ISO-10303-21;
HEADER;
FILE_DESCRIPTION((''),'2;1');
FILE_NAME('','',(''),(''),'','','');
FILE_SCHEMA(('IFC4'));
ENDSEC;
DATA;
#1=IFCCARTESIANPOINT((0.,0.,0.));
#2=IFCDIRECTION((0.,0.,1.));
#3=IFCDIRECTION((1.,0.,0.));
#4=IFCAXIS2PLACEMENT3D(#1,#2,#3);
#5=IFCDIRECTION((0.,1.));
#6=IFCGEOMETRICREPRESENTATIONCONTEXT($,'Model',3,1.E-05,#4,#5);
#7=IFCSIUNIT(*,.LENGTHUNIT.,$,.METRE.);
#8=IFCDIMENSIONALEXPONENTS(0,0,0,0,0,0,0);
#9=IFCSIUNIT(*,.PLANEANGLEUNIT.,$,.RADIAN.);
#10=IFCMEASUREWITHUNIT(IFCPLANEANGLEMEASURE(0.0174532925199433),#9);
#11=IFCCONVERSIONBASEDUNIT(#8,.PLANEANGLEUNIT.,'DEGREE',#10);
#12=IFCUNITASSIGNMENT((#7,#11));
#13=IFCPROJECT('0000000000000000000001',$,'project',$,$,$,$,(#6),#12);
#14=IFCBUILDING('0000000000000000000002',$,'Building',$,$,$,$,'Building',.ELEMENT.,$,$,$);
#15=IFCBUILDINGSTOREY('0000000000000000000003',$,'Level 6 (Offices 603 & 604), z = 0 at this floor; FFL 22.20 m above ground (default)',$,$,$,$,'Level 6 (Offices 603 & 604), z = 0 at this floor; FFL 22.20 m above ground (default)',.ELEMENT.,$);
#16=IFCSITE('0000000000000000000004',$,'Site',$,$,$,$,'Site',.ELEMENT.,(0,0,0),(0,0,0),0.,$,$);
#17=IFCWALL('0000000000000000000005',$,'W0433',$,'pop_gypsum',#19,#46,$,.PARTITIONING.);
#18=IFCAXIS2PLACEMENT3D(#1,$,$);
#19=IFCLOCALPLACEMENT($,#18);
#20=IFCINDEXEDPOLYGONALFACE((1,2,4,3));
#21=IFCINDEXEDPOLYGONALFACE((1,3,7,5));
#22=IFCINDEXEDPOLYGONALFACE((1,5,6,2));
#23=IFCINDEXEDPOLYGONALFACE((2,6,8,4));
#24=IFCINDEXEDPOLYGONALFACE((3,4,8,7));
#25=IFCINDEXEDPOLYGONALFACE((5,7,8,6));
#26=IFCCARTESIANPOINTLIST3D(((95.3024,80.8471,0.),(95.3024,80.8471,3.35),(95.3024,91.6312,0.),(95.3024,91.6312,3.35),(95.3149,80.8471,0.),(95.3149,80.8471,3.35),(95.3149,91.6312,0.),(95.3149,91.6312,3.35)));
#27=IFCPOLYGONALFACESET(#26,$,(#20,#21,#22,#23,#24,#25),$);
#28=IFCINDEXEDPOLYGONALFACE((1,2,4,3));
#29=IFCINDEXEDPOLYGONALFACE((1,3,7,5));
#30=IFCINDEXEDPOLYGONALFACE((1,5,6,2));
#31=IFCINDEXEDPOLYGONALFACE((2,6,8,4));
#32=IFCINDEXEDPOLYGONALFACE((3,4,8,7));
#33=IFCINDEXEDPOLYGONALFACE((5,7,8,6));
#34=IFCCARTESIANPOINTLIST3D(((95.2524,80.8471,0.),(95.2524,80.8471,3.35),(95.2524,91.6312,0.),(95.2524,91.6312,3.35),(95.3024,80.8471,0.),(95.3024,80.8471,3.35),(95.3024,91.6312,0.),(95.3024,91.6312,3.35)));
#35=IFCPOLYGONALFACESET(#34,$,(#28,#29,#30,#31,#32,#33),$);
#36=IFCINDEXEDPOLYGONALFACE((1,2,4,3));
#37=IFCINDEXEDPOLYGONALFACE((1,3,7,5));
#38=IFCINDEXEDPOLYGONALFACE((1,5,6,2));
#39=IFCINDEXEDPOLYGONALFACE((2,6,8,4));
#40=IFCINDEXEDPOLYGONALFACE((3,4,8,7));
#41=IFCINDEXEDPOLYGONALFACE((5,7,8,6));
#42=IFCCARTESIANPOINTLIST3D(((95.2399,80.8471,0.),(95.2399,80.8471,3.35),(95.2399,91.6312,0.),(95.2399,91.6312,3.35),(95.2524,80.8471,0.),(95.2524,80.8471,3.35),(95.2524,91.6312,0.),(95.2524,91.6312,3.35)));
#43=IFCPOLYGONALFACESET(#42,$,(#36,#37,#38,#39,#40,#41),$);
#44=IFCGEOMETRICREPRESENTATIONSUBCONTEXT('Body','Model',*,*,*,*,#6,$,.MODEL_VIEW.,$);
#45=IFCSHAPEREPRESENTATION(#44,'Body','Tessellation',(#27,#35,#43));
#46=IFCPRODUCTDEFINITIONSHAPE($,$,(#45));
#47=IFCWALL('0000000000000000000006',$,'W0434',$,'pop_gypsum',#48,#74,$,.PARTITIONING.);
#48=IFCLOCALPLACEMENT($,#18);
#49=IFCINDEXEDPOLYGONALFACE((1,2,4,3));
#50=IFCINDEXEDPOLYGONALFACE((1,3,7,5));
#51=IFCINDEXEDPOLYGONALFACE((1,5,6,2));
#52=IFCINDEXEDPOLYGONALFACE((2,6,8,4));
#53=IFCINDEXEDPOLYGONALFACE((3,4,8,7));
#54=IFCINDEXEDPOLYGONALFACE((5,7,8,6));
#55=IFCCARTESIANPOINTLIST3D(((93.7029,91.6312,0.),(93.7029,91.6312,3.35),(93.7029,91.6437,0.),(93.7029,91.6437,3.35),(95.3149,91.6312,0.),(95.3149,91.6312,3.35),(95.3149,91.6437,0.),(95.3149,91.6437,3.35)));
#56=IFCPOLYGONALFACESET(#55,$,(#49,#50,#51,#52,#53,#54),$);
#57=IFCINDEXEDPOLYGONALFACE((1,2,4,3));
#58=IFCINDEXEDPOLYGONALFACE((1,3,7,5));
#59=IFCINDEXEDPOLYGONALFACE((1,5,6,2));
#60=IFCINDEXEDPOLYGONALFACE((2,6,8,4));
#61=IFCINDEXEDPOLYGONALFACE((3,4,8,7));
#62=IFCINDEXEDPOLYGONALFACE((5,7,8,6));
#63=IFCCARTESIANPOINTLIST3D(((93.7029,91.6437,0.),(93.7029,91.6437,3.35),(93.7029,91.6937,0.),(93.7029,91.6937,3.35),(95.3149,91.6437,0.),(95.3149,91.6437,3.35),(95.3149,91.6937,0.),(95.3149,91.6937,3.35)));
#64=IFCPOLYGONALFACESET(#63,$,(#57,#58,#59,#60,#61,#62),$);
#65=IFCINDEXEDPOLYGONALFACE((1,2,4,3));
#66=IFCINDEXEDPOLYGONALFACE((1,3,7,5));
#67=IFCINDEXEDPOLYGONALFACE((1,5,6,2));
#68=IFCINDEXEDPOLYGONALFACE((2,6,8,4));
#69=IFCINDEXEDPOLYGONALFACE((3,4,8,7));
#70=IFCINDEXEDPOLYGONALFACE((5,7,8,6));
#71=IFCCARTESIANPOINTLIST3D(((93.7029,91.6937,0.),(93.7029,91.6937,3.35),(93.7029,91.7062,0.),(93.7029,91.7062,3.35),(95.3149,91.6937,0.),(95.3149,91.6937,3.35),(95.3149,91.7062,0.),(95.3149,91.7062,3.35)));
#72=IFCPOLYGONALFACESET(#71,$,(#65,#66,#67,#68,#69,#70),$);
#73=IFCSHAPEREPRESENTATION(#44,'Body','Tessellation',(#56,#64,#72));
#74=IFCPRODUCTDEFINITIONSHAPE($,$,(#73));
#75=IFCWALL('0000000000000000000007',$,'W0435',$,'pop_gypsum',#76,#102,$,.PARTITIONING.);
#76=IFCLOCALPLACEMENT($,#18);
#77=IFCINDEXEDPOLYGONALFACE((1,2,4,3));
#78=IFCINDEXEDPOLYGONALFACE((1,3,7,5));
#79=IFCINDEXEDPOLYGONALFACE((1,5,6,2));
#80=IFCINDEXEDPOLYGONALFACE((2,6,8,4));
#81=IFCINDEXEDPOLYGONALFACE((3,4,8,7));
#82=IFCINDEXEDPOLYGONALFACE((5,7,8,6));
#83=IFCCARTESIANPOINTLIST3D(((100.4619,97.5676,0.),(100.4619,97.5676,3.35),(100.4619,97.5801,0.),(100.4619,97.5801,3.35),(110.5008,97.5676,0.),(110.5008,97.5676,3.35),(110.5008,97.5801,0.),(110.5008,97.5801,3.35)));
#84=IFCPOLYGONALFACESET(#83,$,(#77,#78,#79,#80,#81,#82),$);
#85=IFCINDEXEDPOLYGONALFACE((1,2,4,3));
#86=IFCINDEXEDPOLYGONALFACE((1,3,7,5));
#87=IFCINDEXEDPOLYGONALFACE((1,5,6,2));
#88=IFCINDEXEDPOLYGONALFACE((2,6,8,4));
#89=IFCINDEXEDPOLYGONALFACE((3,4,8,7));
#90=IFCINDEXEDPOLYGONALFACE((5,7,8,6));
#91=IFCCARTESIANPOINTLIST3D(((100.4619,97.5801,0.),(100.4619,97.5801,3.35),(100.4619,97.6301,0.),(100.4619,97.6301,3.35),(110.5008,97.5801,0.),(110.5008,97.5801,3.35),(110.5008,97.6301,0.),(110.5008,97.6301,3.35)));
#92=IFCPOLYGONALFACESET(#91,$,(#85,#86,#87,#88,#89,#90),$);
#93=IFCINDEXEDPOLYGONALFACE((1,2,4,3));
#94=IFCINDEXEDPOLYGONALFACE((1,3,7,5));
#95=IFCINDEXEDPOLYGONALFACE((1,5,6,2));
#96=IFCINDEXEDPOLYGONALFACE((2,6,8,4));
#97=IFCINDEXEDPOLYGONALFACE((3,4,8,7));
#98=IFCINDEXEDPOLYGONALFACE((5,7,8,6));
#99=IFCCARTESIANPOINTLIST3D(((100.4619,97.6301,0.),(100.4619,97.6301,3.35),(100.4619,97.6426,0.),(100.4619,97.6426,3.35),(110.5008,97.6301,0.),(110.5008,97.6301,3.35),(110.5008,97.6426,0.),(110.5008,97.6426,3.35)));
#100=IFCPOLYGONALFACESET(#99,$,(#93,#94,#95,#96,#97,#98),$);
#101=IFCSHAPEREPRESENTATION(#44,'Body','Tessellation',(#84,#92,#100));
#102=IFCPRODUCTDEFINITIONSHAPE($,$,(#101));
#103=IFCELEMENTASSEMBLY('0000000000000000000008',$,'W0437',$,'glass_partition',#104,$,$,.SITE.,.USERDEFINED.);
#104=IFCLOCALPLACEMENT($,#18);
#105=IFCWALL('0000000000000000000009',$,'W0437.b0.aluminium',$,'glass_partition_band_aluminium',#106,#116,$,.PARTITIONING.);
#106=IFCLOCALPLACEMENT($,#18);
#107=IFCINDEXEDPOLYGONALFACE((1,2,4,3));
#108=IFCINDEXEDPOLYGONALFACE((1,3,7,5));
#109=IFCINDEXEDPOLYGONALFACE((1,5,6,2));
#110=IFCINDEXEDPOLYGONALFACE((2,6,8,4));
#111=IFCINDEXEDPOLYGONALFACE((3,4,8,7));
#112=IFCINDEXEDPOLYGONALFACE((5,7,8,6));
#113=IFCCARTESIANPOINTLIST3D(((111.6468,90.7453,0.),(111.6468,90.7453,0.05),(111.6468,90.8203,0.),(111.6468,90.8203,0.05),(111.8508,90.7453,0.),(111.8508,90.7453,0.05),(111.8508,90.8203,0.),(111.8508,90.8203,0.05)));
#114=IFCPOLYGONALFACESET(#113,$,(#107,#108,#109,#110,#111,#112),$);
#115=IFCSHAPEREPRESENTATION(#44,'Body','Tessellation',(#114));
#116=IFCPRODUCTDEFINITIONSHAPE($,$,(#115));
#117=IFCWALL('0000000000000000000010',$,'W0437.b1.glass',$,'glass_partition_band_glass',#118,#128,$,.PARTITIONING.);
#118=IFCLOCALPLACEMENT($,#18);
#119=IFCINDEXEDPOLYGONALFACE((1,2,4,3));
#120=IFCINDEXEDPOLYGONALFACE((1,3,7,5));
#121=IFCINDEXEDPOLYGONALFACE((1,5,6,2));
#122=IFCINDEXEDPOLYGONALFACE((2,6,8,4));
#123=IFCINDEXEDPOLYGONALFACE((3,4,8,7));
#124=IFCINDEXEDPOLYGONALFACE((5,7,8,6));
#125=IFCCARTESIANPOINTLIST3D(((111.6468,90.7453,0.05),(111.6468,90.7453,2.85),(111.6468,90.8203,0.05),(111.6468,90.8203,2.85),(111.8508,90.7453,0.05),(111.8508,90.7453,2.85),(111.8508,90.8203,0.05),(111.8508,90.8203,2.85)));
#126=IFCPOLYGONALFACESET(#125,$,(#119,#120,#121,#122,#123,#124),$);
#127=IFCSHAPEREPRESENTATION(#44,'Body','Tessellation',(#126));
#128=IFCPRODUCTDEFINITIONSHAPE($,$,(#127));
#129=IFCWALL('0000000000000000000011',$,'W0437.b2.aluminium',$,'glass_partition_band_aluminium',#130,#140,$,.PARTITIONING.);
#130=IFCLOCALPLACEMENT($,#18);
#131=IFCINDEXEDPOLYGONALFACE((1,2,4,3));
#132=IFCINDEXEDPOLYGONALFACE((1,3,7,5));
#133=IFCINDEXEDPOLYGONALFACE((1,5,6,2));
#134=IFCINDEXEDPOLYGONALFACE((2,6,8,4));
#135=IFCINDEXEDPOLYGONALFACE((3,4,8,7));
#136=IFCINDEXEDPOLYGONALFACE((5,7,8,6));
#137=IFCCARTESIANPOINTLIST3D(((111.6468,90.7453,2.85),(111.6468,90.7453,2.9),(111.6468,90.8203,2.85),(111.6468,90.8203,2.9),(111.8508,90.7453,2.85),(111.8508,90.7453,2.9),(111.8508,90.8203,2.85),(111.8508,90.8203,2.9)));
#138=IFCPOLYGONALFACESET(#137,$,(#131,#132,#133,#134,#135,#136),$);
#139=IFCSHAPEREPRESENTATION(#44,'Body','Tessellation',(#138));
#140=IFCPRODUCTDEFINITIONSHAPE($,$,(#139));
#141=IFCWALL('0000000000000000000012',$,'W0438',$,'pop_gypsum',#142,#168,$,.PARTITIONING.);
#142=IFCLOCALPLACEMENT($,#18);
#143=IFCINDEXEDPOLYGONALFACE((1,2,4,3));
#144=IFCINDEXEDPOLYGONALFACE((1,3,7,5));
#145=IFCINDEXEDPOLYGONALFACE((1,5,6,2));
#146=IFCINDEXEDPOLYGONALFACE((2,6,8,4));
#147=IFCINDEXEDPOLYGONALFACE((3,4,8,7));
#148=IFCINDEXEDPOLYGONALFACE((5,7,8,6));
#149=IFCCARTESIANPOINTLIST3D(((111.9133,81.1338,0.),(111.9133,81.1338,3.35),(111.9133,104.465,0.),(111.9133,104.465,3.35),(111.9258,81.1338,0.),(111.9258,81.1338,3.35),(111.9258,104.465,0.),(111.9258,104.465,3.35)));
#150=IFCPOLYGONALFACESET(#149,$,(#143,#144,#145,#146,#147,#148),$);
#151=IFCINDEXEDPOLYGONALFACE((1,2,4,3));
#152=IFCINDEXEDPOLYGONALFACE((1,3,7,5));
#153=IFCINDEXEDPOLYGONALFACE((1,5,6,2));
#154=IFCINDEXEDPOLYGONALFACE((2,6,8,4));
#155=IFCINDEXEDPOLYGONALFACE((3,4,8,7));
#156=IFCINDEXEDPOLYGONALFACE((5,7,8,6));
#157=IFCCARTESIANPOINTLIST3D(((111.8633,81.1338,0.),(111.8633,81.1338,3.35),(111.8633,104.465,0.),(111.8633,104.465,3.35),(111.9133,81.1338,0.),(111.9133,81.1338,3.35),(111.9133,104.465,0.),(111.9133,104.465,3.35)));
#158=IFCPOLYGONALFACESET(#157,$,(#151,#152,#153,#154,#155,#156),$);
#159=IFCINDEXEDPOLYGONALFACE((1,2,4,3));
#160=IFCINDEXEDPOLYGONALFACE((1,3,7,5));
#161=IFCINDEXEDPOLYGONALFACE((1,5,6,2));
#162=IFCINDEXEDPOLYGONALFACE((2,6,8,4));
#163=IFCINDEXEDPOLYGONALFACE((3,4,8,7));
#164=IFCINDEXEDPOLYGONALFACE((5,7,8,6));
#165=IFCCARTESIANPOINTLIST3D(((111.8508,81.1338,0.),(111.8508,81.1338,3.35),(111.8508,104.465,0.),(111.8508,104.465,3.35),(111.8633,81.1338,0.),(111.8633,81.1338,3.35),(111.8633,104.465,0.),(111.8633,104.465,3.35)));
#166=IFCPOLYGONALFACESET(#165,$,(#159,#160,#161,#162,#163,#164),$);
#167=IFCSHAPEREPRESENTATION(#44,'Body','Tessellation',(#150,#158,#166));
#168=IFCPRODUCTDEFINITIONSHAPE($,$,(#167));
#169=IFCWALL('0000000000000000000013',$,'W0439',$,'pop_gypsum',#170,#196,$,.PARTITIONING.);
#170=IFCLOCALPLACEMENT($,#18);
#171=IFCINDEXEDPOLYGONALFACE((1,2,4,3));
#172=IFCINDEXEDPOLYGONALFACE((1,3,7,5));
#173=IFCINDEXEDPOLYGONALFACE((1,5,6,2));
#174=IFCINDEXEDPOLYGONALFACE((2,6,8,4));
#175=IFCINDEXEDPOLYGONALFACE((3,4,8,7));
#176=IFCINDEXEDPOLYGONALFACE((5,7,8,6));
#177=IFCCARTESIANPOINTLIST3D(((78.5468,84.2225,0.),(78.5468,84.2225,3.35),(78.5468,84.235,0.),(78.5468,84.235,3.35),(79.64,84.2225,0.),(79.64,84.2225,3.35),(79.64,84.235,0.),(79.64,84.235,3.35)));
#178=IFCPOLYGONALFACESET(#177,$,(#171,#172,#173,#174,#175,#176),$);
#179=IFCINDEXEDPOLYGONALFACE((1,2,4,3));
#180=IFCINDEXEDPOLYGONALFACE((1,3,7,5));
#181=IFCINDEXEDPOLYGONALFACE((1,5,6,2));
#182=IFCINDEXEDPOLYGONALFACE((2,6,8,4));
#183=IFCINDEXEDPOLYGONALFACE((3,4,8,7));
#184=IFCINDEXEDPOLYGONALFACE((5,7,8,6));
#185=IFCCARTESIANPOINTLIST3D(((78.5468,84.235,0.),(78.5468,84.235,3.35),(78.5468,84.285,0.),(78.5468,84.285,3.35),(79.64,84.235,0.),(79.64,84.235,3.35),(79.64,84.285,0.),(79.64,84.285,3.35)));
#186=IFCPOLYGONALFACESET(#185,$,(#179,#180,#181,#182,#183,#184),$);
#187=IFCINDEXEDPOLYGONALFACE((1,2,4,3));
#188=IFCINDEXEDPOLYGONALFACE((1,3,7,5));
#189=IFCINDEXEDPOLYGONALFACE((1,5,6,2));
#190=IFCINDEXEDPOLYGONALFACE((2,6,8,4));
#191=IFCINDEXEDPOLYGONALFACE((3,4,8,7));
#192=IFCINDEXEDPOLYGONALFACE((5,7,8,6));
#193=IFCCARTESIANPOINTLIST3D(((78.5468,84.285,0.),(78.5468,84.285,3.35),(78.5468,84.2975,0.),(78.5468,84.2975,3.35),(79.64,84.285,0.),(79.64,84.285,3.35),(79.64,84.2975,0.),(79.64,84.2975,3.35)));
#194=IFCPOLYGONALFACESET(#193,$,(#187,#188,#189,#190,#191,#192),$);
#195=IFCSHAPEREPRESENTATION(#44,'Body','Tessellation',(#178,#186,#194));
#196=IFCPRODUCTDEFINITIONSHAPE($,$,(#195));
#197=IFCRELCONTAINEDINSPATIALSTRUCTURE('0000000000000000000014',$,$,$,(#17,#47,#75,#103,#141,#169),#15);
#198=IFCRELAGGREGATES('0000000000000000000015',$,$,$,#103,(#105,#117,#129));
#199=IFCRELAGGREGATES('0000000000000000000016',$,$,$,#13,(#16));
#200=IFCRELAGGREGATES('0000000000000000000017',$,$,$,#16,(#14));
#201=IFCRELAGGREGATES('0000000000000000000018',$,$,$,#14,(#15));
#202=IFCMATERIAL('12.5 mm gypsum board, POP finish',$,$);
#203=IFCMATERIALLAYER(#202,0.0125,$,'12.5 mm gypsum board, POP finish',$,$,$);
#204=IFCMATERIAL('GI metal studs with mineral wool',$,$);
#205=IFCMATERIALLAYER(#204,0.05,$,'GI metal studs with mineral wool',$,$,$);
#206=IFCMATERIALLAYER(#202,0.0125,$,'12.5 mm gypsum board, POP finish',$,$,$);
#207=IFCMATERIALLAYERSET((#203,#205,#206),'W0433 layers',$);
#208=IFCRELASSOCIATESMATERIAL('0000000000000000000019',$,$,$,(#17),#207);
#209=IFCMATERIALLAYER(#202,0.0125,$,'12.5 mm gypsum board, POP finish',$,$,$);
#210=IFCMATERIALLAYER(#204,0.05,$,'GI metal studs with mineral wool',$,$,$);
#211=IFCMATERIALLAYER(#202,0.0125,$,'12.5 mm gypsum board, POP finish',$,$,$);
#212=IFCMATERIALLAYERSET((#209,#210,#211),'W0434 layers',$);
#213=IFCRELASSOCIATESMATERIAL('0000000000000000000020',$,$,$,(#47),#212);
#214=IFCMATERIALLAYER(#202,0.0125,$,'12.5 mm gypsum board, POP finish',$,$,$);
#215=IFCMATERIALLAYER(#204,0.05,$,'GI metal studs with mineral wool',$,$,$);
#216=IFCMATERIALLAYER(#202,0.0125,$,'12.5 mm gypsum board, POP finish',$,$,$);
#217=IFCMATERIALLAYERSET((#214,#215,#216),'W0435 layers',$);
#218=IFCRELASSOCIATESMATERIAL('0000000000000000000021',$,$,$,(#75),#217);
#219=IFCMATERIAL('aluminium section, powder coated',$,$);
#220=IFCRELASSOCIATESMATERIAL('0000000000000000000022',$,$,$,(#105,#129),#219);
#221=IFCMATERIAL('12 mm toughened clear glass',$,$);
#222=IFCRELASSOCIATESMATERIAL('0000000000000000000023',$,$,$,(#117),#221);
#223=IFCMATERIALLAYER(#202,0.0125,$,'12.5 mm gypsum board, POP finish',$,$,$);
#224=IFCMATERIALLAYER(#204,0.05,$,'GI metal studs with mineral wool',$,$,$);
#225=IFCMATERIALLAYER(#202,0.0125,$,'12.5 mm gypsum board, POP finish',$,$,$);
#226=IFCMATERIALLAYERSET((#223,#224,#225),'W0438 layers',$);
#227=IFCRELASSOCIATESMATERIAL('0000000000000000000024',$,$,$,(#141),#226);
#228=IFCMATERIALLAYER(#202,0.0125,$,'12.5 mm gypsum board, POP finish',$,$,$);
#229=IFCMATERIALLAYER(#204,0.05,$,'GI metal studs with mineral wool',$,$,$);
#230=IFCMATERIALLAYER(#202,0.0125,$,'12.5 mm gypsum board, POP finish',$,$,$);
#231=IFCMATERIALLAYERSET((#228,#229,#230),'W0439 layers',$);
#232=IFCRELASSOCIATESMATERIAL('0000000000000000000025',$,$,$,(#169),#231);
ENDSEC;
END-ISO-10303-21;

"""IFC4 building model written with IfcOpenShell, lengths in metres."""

from ifc_helpers import new_model, entity, si_unit, converted_unit, direction, frame, frame_2d, origin_with_axes, origin_2d_with_axis, place, context, subcontext, project, spatial, rectangle, extrude, material, layer, layer_set, layer_usage, element, aggregate, save


model = new_model("IFC4")

# Units and contexts
model_context = context("Model", 3, precision=1e-05, world=origin_with_axes(), true_north=direction((0.0, 1.0)))
body_context = subcontext(model_context, "Body", "Model", "MODEL_VIEW")
ifc_project = project(units=[si_unit("LENGTHUNIT", "METRE"), converted_unit("PLANEANGLEUNIT", "DEGREE", entity("IfcPlaneAngleMeasure", 0.0174532925199433), si_unit("PLANEANGLEUNIT", "RADIAN"), dimensions=[0, 0, 0, 0, 0, 0, 0])], contexts=[model_context])

# Site, building, storey
site = spatial("IfcSite", under=ifc_project, Name="Site", LongName="Site", CompositionType="ELEMENT", RefLatitude=(0, 0, 0), RefLongitude=(0, 0, 0), RefElevation=0.0)
building = spatial("IfcBuilding", under=site, Name="Building", LongName="Building", CompositionType="ELEMENT")
storey = spatial("IfcBuildingStorey", under=building, Name="Level 6 (Offices 603 & 604), z = 0 at this floor; FFL 22.20 m above ground (default)", LongName="Level 6 (Offices 603 & 604), z = 0 at this floor; FFL 22.20 m above ground (default)", CompositionType="ELEMENT")

# Shared definitions
ifc_material_1 = material(Name="aluminium section, powder coated")
placement = place(None, origin_with_axes())

# Shared definitions
ifc_material_2 = material(Name="12.5 mm gypsum board, POP finish")
ifc_material_3 = material(Name="GI metal studs with mineral wool")

# Shared definitions
ifc_material_4 = material(Name="12 mm toughened clear glass")

# Walls
ifc_layer_1 = layer(ifc_material_2, 0.0125, Name="12.5 mm gypsum board, POP finish")
ifc_layer_2 = layer(ifc_material_3, 0.05, Name="GI metal studs with mineral wool")
ifc_layer_3 = layer(ifc_material_2, 0.0125, Name="12.5 mm gypsum board, POP finish")
ifc_layer_set_1 = layer_set([ifc_layer_1, ifc_layer_2, ifc_layer_3], Name="W0433 layers")
ifc_layer_usage_1 = layer_usage(ifc_layer_set_1, "AXIS2", "POSITIVE", -0.0375)
element("IfcWall", 1, at=placement, inside=storey, material=ifc_layer_usage_1, Name="W0433", ObjectType="pop_gypsum", PredefinedType="PARTITIONING", context=body_context, shape_type="SweptSolid", body=[
    extrude(rectangle(XDim=10.7841, YDim=0.0125, at=frame_2d((0.0, 0.0), x_axis=(0.0, 1.0))), frame((95.3087, 86.2391, 0.0), z_axis=(0.0, 0.0, 1.0), x_axis=(1.0, 0.0, 0.0)), (0.0, 0.0, 1.0), 3.35),
    extrude(rectangle(XDim=10.7841, YDim=0.05, at=frame_2d((-0.0312, 0.0), x_axis=(0.0, 1.0))), frame((95.3087, 86.2391, 0.0), z_axis=(0.0, 0.0, 1.0), x_axis=(1.0, 0.0, 0.0)), (0.0, 0.0, 1.0), 3.35),
    extrude(rectangle(XDim=10.7841, YDim=0.0125, at=frame_2d((-0.0625, 0.0), x_axis=(0.0, 1.0))), frame((95.3087, 86.2391, 0.0), z_axis=(0.0, 0.0, 1.0), x_axis=(1.0, 0.0, 0.0)), (0.0, 0.0, 1.0), 3.35),
])
ifc_layer_4 = layer(ifc_material_2, 0.0125, Name="12.5 mm gypsum board, POP finish")
ifc_layer_5 = layer(ifc_material_3, 0.05, Name="GI metal studs with mineral wool")
ifc_layer_6 = layer(ifc_material_2, 0.0125, Name="12.5 mm gypsum board, POP finish")
ifc_layer_set_2 = layer_set([ifc_layer_4, ifc_layer_5, ifc_layer_6], Name="W0434 layers")
ifc_layer_usage_2 = layer_usage(ifc_layer_set_2, "AXIS2", "POSITIVE", -0.0375)
element("IfcWall", 2, at=placement, inside=storey, material=ifc_layer_usage_2, Name="W0434", ObjectType="pop_gypsum", PredefinedType="PARTITIONING", context=body_context, shape_type="SweptSolid", body=[
    extrude(rectangle(XDim=1.612, YDim=0.0125, at=frame_2d((0.0, 0.0), x_axis=(1.0, 0.0))), frame((94.5089, 91.6375, 0.0), z_axis=(0.0, 0.0, 1.0), x_axis=(1.0, 0.0, 0.0)), (0.0, 0.0, 1.0), 3.35),
    extrude(rectangle(XDim=1.612, YDim=0.05, at=frame_2d((0.0, 0.0313), x_axis=(1.0, 0.0))), frame((94.5089, 91.6375, 0.0), z_axis=(0.0, 0.0, 1.0), x_axis=(1.0, 0.0, 0.0)), (0.0, 0.0, 1.0), 3.35),
    extrude(rectangle(XDim=1.612, YDim=0.0125, at=frame_2d((0.0, 0.0625), x_axis=(1.0, 0.0))), frame((94.5089, 91.6375, 0.0), z_axis=(0.0, 0.0, 1.0), x_axis=(1.0, 0.0, 0.0)), (0.0, 0.0, 1.0), 3.35),
])
ifc_layer_7 = layer(ifc_material_2, 0.0125, Name="12.5 mm gypsum board, POP finish")
ifc_layer_8 = layer(ifc_material_3, 0.05, Name="GI metal studs with mineral wool")
ifc_layer_9 = layer(ifc_material_2, 0.0125, Name="12.5 mm gypsum board, POP finish")
ifc_layer_set_3 = layer_set([ifc_layer_7, ifc_layer_8, ifc_layer_9], Name="W0435 layers")
ifc_layer_usage_3 = layer_usage(ifc_layer_set_3, "AXIS2", "POSITIVE", -0.0375)
element("IfcWall", 3, at=placement, inside=storey, material=ifc_layer_usage_3, Name="W0435", ObjectType="pop_gypsum", PredefinedType="PARTITIONING", context=body_context, shape_type="SweptSolid", body=[
    extrude(rectangle(XDim=10.0389, YDim=0.0125, at=frame_2d((0.0, 0.0), x_axis=(1.0, 0.0))), frame((105.4814, 97.5738, 0.0), z_axis=(0.0, 0.0, 1.0), x_axis=(1.0, 0.0, 0.0)), (0.0, 0.0, 1.0), 3.35),
    extrude(rectangle(XDim=10.0389, YDim=0.05, at=frame_2d((0.0, 0.0312), x_axis=(1.0, 0.0))), frame((105.4814, 97.5738, 0.0), z_axis=(0.0, 0.0, 1.0), x_axis=(1.0, 0.0, 0.0)), (0.0, 0.0, 1.0), 3.35),
    extrude(rectangle(XDim=10.0389, YDim=0.0125, at=frame_2d((0.0, 0.0625), x_axis=(1.0, 0.0))), frame((105.4814, 97.5738, 0.0), z_axis=(0.0, 0.0, 1.0), x_axis=(1.0, 0.0, 0.0)), (0.0, 0.0, 1.0), 3.35),
])

# Element assembly, walls
assembly_1 = element("IfcElementAssembly", 4, inside=storey, Name="W0437", ObjectType="glass_partition", AssemblyPlace="SITE", PredefinedType="USERDEFINED")
wall_1 = element("IfcWall", 5, at=placement, material=ifc_material_1, Name="W0437.b0.aluminium", ObjectType="glass_partition_band_aluminium", PredefinedType="PARTITIONING", context=body_context, shape_type="SweptSolid", body=[
    extrude(rectangle(XDim=0.204, YDim=0.075, at=origin_2d_with_axis()), frame((111.7488, 90.7828, 0.0), z_axis=(0.0, 0.0, 1.0), x_axis=(1.0, 0.0, 0.0)), (0.0, 0.0, 1.0), 0.05),
])
wall_2 = element("IfcWall", 6, at=placement, material=ifc_material_4, Name="W0437.b1.glass", ObjectType="glass_partition_band_glass", PredefinedType="PARTITIONING", context=body_context, shape_type="SweptSolid", body=[
    extrude(rectangle(XDim=0.204, YDim=0.075, at=origin_2d_with_axis()), frame((111.7488, 90.7828, 0.05), z_axis=(0.0, 0.0, 1.0), x_axis=(1.0, 0.0, 0.0)), (0.0, 0.0, 1.0), 2.8),
])
wall_3 = element("IfcWall", 7, at=placement, material=ifc_material_1, Name="W0437.b2.aluminium", ObjectType="glass_partition_band_aluminium", PredefinedType="PARTITIONING", context=body_context, shape_type="SweptSolid", body=[
    extrude(rectangle(XDim=0.204, YDim=0.075, at=origin_2d_with_axis()), frame((111.7488, 90.7828, 2.85), z_axis=(0.0, 0.0, 1.0), x_axis=(1.0, 0.0, 0.0)), (0.0, 0.0, 1.0), 0.05),
])
aggregate(assembly_1, [wall_1, wall_2, wall_3])

# Walls
ifc_layer_10 = layer(ifc_material_2, 0.0125, Name="12.5 mm gypsum board, POP finish")
ifc_layer_11 = layer(ifc_material_3, 0.05, Name="GI metal studs with mineral wool")
ifc_layer_12 = layer(ifc_material_2, 0.0125, Name="12.5 mm gypsum board, POP finish")
ifc_layer_set_4 = layer_set([ifc_layer_10, ifc_layer_11, ifc_layer_12], Name="W0438 layers")
ifc_layer_usage_4 = layer_usage(ifc_layer_set_4, "AXIS2", "POSITIVE", -0.0375)
element("IfcWall", 8, at=placement, inside=storey, material=ifc_layer_usage_4, Name="W0438", ObjectType="pop_gypsum", PredefinedType="PARTITIONING", context=body_context, shape_type="SweptSolid", body=[
    extrude(rectangle(XDim=23.3312, YDim=0.0125, at=frame_2d((0.0, 0.0), x_axis=(0.0, 1.0))), frame((111.9196, 92.7994, 0.0), z_axis=(0.0, 0.0, 1.0), x_axis=(1.0, 0.0, 0.0)), (0.0, 0.0, 1.0), 3.35),
    extrude(rectangle(XDim=23.3312, YDim=0.05, at=frame_2d((-0.0312, 0.0), x_axis=(0.0, 1.0))), frame((111.9196, 92.7994, 0.0), z_axis=(0.0, 0.0, 1.0), x_axis=(1.0, 0.0, 0.0)), (0.0, 0.0, 1.0), 3.35),
    extrude(rectangle(XDim=23.3312, YDim=0.0125, at=frame_2d((-0.0625, 0.0), x_axis=(0.0, 1.0))), frame((111.9196, 92.7994, 0.0), z_axis=(0.0, 0.0, 1.0), x_axis=(1.0, 0.0, 0.0)), (0.0, 0.0, 1.0), 3.35),
])
ifc_layer_13 = layer(ifc_material_2, 0.0125, Name="12.5 mm gypsum board, POP finish")
ifc_layer_14 = layer(ifc_material_3, 0.05, Name="GI metal studs with mineral wool")
ifc_layer_15 = layer(ifc_material_2, 0.0125, Name="12.5 mm gypsum board, POP finish")
ifc_layer_set_5 = layer_set([ifc_layer_13, ifc_layer_14, ifc_layer_15], Name="W0439 layers")
ifc_layer_usage_5 = layer_usage(ifc_layer_set_5, "AXIS2", "POSITIVE", -0.0375)
element("IfcWall", 9, at=placement, inside=storey, material=ifc_layer_usage_5, Name="W0439", ObjectType="pop_gypsum", PredefinedType="PARTITIONING", context=body_context, shape_type="SweptSolid", body=[
    extrude(rectangle(XDim=1.0932, YDim=0.0125, at=frame_2d((0.0, 0.0), x_axis=(1.0, 0.0))), frame((79.0934, 84.2288, 0.0), z_axis=(0.0, 0.0, 1.0), x_axis=(1.0, 0.0, 0.0)), (0.0, 0.0, 1.0), 3.35),
    extrude(rectangle(XDim=1.0932, YDim=0.05, at=frame_2d((0.0, 0.0312), x_axis=(1.0, 0.0))), frame((79.0934, 84.2288, 0.0), z_axis=(0.0, 0.0, 1.0), x_axis=(1.0, 0.0, 0.0)), (0.0, 0.0, 1.0), 3.35),
    extrude(rectangle(XDim=1.0932, YDim=0.0125, at=frame_2d((0.0, 0.0625), x_axis=(1.0, 0.0))), frame((79.0934, 84.2288, 0.0), z_axis=(0.0, 0.0, 1.0), x_axis=(1.0, 0.0, 0.0)), (0.0, 0.0, 1.0), 3.35),
])

save(model, "model.ifc")
